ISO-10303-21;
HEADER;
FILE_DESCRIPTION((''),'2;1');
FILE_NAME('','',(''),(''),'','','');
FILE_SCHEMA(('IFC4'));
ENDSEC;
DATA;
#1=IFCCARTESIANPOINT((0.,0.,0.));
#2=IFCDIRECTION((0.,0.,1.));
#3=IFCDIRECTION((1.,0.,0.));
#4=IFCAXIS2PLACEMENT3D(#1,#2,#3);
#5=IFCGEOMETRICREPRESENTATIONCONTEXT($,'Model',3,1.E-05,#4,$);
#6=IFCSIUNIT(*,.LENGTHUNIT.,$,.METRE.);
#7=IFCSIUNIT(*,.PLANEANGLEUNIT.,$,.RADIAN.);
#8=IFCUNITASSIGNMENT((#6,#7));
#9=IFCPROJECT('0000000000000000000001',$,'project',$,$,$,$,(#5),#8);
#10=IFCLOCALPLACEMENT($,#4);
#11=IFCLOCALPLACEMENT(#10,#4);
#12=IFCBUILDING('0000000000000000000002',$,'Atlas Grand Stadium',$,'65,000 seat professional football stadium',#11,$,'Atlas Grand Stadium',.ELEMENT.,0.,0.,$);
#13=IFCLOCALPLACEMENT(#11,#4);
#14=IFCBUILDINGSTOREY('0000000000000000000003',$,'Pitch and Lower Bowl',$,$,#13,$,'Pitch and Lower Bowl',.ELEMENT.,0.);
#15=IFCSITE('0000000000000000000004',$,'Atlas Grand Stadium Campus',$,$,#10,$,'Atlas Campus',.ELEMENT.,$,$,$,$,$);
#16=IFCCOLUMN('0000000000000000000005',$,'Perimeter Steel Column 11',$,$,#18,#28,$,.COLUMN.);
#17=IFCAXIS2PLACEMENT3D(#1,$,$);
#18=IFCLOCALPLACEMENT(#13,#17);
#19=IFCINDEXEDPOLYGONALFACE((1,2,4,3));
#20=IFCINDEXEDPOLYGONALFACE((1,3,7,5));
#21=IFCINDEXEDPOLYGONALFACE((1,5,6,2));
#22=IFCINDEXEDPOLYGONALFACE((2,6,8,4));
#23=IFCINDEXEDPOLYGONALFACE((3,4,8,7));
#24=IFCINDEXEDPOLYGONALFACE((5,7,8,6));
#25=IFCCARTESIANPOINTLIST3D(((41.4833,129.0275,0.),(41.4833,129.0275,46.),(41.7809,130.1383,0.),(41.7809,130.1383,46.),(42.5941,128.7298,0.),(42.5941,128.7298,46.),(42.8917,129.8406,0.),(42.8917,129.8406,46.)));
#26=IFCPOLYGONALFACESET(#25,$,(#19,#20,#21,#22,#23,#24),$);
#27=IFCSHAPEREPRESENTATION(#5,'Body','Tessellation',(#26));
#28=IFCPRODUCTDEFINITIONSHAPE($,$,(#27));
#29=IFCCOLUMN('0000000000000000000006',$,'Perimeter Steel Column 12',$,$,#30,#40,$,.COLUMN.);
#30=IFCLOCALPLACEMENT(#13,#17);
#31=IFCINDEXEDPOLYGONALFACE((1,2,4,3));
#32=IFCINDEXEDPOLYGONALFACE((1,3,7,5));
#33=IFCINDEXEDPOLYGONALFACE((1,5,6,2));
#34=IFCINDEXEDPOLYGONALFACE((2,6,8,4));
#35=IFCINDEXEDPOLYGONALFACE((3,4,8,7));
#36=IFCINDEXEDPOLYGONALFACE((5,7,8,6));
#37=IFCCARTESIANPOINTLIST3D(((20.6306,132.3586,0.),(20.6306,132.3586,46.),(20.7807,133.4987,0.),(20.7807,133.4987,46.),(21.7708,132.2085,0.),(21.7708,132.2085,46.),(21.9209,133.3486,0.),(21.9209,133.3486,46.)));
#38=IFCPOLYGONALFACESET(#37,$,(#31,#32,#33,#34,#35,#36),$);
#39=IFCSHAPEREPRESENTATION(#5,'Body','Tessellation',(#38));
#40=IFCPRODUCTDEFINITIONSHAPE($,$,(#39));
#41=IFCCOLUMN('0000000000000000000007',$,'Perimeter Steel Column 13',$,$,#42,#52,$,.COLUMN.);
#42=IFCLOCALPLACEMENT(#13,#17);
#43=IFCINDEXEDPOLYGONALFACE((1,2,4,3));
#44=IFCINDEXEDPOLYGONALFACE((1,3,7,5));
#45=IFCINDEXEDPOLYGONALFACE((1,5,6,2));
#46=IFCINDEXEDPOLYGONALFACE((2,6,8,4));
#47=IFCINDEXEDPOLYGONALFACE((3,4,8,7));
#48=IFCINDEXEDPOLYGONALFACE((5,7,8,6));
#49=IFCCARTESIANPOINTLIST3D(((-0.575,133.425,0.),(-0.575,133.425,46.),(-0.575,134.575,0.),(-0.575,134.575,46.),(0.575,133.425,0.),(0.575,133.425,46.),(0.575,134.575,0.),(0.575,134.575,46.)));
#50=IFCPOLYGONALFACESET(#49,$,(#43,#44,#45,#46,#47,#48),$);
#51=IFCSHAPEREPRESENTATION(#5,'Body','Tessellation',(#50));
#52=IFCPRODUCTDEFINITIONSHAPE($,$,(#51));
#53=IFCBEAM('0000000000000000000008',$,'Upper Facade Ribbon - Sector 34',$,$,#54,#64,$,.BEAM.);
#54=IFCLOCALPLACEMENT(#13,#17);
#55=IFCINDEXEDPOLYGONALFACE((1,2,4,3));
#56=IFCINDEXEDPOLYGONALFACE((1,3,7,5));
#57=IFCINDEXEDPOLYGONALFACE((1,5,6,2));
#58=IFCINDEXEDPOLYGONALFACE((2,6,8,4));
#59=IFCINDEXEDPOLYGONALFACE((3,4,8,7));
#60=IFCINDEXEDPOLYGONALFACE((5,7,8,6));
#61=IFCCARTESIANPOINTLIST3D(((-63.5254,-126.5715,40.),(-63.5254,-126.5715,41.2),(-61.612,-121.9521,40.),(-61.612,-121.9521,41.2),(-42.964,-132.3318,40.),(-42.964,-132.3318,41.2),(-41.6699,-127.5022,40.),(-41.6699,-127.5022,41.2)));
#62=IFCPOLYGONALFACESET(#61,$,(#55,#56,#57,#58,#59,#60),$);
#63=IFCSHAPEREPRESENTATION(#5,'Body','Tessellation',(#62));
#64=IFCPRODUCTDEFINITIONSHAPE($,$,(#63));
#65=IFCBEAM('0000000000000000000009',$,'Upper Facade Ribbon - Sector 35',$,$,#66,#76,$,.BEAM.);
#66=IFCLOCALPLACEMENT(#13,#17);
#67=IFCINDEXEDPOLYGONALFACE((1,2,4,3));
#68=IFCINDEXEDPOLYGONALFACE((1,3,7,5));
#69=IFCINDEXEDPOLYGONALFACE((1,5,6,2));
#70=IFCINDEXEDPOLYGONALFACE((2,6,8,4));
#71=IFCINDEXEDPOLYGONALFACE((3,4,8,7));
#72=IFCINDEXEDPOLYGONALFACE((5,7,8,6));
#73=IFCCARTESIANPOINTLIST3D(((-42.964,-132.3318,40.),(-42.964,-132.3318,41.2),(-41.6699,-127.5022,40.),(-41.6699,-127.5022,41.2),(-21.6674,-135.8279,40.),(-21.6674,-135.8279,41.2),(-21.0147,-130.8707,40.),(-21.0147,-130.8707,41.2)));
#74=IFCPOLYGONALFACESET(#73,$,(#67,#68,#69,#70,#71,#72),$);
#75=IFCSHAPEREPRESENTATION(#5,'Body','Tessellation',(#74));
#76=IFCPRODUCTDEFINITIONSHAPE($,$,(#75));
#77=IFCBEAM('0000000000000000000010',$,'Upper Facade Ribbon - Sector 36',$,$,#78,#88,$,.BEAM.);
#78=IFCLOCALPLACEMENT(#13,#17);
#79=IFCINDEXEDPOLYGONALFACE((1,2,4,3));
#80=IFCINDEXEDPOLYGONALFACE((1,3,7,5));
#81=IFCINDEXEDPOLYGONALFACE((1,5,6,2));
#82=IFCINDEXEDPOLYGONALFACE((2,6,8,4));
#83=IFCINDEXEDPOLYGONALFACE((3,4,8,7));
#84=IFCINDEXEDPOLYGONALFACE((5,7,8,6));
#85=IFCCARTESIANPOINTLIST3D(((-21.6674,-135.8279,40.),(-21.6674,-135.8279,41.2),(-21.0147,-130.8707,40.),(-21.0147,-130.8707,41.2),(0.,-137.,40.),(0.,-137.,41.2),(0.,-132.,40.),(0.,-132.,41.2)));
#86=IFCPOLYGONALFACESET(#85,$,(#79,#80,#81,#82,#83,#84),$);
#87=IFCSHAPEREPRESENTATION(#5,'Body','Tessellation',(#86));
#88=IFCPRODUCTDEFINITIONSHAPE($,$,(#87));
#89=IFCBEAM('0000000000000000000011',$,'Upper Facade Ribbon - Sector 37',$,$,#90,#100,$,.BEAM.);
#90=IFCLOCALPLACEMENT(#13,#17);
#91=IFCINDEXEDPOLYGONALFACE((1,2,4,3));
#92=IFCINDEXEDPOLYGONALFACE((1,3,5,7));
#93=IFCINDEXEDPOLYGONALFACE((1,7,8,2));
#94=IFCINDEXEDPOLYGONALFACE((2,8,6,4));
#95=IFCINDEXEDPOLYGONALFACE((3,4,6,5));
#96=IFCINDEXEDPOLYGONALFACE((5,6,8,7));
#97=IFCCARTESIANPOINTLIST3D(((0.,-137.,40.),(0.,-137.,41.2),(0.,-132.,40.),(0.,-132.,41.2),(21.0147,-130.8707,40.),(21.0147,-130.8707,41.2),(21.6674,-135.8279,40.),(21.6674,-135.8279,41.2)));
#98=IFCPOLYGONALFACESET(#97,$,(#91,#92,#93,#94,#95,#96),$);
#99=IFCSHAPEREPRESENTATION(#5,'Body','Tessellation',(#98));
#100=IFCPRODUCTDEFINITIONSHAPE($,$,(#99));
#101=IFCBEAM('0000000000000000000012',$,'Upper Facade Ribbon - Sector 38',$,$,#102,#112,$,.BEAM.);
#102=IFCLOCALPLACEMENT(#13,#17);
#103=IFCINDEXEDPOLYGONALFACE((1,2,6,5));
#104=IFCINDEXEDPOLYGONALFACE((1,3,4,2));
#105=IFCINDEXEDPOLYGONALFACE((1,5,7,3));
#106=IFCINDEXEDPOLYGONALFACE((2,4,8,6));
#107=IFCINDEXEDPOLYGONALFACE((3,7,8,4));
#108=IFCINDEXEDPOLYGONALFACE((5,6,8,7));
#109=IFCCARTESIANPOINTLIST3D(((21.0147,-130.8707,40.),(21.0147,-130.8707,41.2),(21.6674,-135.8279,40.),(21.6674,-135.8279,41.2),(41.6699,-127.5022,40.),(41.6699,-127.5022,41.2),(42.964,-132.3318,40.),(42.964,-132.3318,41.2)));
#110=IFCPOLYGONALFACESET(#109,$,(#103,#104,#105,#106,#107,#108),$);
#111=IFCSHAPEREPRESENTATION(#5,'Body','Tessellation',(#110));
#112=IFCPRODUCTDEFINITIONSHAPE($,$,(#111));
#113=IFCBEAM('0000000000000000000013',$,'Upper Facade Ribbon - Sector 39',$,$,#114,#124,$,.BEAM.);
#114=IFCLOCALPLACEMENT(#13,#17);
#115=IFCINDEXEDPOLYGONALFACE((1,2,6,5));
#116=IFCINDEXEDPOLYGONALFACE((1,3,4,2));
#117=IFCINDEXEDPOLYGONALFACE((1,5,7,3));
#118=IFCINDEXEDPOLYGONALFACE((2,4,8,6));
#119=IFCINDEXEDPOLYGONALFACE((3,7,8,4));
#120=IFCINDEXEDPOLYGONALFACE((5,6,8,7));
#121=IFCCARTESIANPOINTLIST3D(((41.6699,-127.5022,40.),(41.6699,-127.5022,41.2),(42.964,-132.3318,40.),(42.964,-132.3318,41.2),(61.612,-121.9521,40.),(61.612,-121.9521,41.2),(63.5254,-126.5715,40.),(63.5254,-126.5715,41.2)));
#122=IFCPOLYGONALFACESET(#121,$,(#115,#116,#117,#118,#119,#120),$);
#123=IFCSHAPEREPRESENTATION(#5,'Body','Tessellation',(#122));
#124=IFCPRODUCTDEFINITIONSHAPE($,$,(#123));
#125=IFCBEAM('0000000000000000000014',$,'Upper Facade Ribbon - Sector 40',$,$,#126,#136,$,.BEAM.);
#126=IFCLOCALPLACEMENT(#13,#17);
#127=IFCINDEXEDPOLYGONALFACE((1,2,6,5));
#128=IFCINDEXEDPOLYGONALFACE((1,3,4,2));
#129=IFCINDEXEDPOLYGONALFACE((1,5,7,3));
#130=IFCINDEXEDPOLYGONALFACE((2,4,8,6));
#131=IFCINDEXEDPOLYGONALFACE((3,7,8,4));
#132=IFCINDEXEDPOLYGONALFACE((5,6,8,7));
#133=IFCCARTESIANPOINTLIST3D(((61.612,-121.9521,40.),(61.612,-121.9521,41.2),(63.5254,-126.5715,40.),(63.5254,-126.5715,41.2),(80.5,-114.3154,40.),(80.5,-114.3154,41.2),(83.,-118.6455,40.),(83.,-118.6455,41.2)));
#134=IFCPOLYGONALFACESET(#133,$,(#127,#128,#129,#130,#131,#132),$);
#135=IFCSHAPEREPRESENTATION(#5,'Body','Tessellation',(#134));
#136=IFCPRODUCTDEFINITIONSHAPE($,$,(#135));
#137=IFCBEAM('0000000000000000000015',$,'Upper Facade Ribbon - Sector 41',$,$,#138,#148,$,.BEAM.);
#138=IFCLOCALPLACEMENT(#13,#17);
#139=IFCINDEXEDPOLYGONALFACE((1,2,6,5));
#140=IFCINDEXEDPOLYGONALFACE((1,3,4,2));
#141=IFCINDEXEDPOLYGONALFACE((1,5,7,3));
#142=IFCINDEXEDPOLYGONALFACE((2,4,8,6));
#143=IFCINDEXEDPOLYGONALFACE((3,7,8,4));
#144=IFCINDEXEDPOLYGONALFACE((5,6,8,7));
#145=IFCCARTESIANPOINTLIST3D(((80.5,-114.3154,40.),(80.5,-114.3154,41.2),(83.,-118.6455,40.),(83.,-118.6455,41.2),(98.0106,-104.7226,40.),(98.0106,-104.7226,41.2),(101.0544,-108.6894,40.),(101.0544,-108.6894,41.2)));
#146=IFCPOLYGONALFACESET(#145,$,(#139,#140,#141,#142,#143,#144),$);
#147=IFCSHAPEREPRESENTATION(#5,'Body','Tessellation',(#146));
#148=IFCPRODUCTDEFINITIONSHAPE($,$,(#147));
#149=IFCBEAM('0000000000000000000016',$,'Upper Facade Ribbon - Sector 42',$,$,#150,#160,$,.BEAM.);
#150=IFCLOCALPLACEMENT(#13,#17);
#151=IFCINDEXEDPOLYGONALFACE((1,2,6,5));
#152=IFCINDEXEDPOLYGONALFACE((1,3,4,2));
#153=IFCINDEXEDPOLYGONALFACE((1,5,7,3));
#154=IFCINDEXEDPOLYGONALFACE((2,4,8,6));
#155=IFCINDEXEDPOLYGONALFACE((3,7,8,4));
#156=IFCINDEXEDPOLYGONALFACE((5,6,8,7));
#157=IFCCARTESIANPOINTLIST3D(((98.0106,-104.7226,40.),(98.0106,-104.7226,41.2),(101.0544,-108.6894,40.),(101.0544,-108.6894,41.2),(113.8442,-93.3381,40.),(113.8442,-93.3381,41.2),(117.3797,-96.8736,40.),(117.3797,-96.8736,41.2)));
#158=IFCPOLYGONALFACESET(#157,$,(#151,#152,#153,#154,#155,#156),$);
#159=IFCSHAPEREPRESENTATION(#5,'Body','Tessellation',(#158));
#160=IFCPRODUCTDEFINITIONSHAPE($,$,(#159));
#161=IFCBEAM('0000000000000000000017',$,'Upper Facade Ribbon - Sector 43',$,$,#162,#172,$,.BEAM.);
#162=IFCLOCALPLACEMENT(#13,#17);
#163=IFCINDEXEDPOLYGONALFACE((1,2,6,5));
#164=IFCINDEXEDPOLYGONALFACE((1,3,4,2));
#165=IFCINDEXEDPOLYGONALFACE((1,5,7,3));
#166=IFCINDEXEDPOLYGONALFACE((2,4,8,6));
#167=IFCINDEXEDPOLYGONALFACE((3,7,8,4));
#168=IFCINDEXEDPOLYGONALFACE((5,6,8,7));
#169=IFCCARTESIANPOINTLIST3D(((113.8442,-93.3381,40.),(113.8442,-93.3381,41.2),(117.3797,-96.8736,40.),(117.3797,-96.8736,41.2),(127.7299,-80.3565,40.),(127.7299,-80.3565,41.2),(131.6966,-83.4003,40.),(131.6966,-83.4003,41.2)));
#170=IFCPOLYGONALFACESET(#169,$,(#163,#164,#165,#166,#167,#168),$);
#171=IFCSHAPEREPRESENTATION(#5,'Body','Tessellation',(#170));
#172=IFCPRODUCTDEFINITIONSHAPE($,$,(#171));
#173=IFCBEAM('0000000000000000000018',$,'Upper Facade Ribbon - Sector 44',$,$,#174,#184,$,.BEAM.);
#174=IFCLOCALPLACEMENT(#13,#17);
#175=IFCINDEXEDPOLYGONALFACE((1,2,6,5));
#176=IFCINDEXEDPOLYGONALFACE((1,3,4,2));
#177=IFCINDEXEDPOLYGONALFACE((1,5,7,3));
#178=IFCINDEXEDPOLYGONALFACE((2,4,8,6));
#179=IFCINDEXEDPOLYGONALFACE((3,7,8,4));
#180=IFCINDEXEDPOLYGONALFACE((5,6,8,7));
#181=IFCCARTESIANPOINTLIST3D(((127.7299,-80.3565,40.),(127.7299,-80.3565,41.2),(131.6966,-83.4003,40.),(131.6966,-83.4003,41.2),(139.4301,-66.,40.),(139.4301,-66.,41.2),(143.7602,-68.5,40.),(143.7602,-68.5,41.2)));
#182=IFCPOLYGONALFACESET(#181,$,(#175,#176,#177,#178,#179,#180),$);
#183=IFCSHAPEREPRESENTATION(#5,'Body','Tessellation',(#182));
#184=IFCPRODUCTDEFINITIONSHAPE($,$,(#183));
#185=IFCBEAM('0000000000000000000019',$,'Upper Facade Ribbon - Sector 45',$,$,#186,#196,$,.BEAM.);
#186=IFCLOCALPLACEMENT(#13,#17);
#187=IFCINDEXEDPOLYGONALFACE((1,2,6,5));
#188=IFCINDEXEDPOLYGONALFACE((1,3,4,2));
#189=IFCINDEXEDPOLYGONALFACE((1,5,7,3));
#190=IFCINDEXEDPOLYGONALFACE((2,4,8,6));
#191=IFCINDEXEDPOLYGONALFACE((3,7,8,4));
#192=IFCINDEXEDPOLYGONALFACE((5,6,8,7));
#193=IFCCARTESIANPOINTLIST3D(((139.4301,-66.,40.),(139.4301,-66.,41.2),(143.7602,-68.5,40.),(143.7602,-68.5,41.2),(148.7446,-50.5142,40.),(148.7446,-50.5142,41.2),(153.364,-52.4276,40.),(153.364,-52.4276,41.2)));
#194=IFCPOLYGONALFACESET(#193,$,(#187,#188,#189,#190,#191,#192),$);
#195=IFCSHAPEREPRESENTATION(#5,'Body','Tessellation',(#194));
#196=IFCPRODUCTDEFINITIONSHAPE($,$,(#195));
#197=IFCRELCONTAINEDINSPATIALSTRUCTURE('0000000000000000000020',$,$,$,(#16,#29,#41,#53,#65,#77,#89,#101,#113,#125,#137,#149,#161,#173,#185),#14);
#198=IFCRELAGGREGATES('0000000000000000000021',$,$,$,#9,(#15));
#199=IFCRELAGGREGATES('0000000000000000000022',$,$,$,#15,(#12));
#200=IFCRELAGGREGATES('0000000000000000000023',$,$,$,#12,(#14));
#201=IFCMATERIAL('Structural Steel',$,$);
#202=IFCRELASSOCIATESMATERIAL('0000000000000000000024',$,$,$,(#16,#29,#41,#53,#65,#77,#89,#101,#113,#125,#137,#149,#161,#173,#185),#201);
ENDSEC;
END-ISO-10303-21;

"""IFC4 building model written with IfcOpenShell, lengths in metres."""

from ifc_helpers import new_model, si_unit, frame, origin_with_axes, origin_2d_with_axis, place, context, project, spatial, polyline, rectangle, outline, extrude, material, element, save


model = new_model("IFC4")

# Units and contexts
model_context = context("Model", 3, precision=1e-05, world=origin_with_axes())
ifc_project = project(units=[si_unit("LENGTHUNIT", "METRE"), si_unit("PLANEANGLEUNIT", "RADIAN")], contexts=[model_context])

# Site, building, storey
site_placement = place(None, origin_with_axes())
site = spatial("IfcSite", under=ifc_project, at=site_placement, Name="Atlas Grand Stadium Campus", LongName="Atlas Campus", CompositionType="ELEMENT")
building_placement = place(site_placement, origin_with_axes())
building = spatial("IfcBuilding", under=site, at=building_placement, Name="Atlas Grand Stadium", ObjectType="65,000 seat professional football stadium", LongName="Atlas Grand Stadium", CompositionType="ELEMENT", ElevationOfRefHeight=0.0, ElevationOfTerrain=0.0)
storey_placement = place(building_placement, origin_with_axes())
storey = spatial("IfcBuildingStorey", under=building, at=storey_placement, Name="Pitch and Lower Bowl", LongName="Pitch and Lower Bowl", CompositionType="ELEMENT", Elevation=0.0)

# Columns
ifc_material_1 = material(Name="Structural Steel")
for number, where, z_axis, x_axis, name in (
    (1, (42.1875, 129.4341, 0.0), (0.0, 0.0, 1.0), (-0.96593, 0.25882, 0.0), "Perimeter Steel Column 11"),
    (2, (21.2758, 132.8536, 0.0), (0.0, 0.0, 1.0), (-0.99144, 0.13053, 0.0), "Perimeter Steel Column 12"),
    (3, (0.0, 134.0, 0.0), (0.0, 0.0, 1.0), (-1.0, 0.0, 0.0), "Perimeter Steel Column 13"),
):
    element("IfcColumn", number, at=place(storey_placement, frame(where, z_axis=z_axis, x_axis=x_axis)), inside=storey, material=ifc_material_1, Name=name, PredefinedType="COLUMN", context=model_context, shape_type="SweptSolid", body=[
        extrude(rectangle(XDim=1.15, YDim=1.15, at=origin_2d_with_axis()), origin_with_axes(), (0.0, 0.0, 1.0), 46.0),
    ])

# Beams
beam_1_placement = place(storey_placement, frame((0.0, 0.0, 40.0), z_axis=(0.0, 0.0, 1.0), x_axis=(1.0, 0.0, 0.0)))
element("IfcBeam", 4, at=beam_1_placement, inside=storey, material=ifc_material_1, Name="Upper Facade Ribbon - Sector 34", PredefinedType="BEAM", context=model_context, shape_type="SweptSolid", body=[
    extrude(outline(polyline([(-63.5254, -126.5715), (-42.964, -132.3318), (-41.6699, -127.5022), (-61.612, -121.9521), (-63.5254, -126.5715)])), origin_with_axes(), (0.0, 0.0, 1.0), 1.2),
])
beam_2_placement = place(storey_placement, frame((0.0, 0.0, 40.0), z_axis=(0.0, 0.0, 1.0), x_axis=(1.0, 0.0, 0.0)))
element("IfcBeam", 5, at=beam_2_placement, inside=storey, material=ifc_material_1, Name="Upper Facade Ribbon - Sector 35", PredefinedType="BEAM", context=model_context, shape_type="SweptSolid", body=[
    extrude(outline(polyline([(-42.964, -132.3318), (-21.6673, -135.8279), (-21.0147, -130.8707), (-41.6699, -127.5022), (-42.964, -132.3318)])), origin_with_axes(), (0.0, 0.0, 1.0), 1.2),
])
beam_3_placement = place(storey_placement, frame((0.0, 0.0, 40.0), z_axis=(0.0, 0.0, 1.0), x_axis=(1.0, 0.0, 0.0)))
element("IfcBeam", 6, at=beam_3_placement, inside=storey, material=ifc_material_1, Name="Upper Facade Ribbon - Sector 36", PredefinedType="BEAM", context=model_context, shape_type="SweptSolid", body=[
    extrude(outline(polyline([(-21.6673, -135.8279), (0.0, -137.0), (0.0, -132.0), (-21.0147, -130.8707), (-21.6673, -135.8279)])), origin_with_axes(), (0.0, 0.0, 1.0), 1.2),
])
beam_4_placement = place(storey_placement, frame((0.0, 0.0, 40.0), z_axis=(0.0, 0.0, 1.0), x_axis=(1.0, 0.0, 0.0)))
element("IfcBeam", 7, at=beam_4_placement, inside=storey, material=ifc_material_1, Name="Upper Facade Ribbon - Sector 37", PredefinedType="BEAM", context=model_context, shape_type="SweptSolid", body=[
    extrude(outline(polyline([(0.0, -137.0), (21.6673, -135.8279), (21.0147, -130.8707), (0.0, -132.0), (0.0, -137.0)])), origin_with_axes(), (0.0, 0.0, 1.0), 1.2),
])
beam_5_placement = place(storey_placement, frame((0.0, 0.0, 40.0), z_axis=(0.0, 0.0, 1.0), x_axis=(1.0, 0.0, 0.0)))
element("IfcBeam", 8, at=beam_5_placement, inside=storey, material=ifc_material_1, Name="Upper Facade Ribbon - Sector 38", PredefinedType="BEAM", context=model_context, shape_type="SweptSolid", body=[
    extrude(outline(polyline([(21.6673, -135.8279), (42.964, -132.3318), (41.6699, -127.5022), (21.0147, -130.8707), (21.6673, -135.8279)])), origin_with_axes(), (0.0, 0.0, 1.0), 1.2),
])
beam_6_placement = place(storey_placement, frame((0.0, 0.0, 40.0), z_axis=(0.0, 0.0, 1.0), x_axis=(1.0, 0.0, 0.0)))
element("IfcBeam", 9, at=beam_6_placement, inside=storey, material=ifc_material_1, Name="Upper Facade Ribbon - Sector 39", PredefinedType="BEAM", context=model_context, shape_type="SweptSolid", body=[
    extrude(outline(polyline([(42.964, -132.3318), (63.5254, -126.5715), (61.612, -121.9521), (41.6699, -127.5022), (42.964, -132.3318)])), origin_with_axes(), (0.0, 0.0, 1.0), 1.2),
])
beam_7_placement = place(storey_placement, frame((0.0, 0.0, 40.0), z_axis=(0.0, 0.0, 1.0), x_axis=(1.0, 0.0, 0.0)))
element("IfcBeam", 10, at=beam_7_placement, inside=storey, material=ifc_material_1, Name="Upper Facade Ribbon - Sector 40", PredefinedType="BEAM", context=model_context, shape_type="SweptSolid", body=[
    extrude(outline(polyline([(63.5254, -126.5715), (83.0, -118.6455), (80.5, -114.3153), (61.612, -121.9521), (63.5254, -126.5715)])), origin_with_axes(), (0.0, 0.0, 1.0), 1.2),
])
beam_8_placement = place(storey_placement, frame((0.0, 0.0, 40.0), z_axis=(0.0, 0.0, 1.0), x_axis=(1.0, 0.0, 0.0)))
element("IfcBeam", 11, at=beam_8_placement, inside=storey, material=ifc_material_1, Name="Upper Facade Ribbon - Sector 41", PredefinedType="BEAM", context=model_context, shape_type="SweptSolid", body=[
    extrude(outline(polyline([(83.0, -118.6455), (101.0544, -108.6894), (98.0106, -104.7226), (80.5, -114.3153), (83.0, -118.6455)])), origin_with_axes(), (0.0, 0.0, 1.0), 1.2),
])
beam_9_placement = place(storey_placement, frame((0.0, 0.0, 40.0), z_axis=(0.0, 0.0, 1.0), x_axis=(1.0, 0.0, 0.0)))
element("IfcBeam", 12, at=beam_9_placement, inside=storey, material=ifc_material_1, Name="Upper Facade Ribbon - Sector 42", PredefinedType="BEAM", context=model_context, shape_type="SweptSolid", body=[
    extrude(outline(polyline([(101.0544, -108.6894), (117.3797, -96.8736), (113.8442, -93.3381), (98.0106, -104.7226), (101.0544, -108.6894)])), origin_with_axes(), (0.0, 0.0, 1.0), 1.2),
])
beam_10_placement = place(storey_placement, frame((0.0, 0.0, 40.0), z_axis=(0.0, 0.0, 1.0), x_axis=(1.0, 0.0, 0.0)))
element("IfcBeam", 13, at=beam_10_placement, inside=storey, material=ifc_material_1, Name="Upper Facade Ribbon - Sector 43", PredefinedType="BEAM", context=model_context, shape_type="SweptSolid", body=[
    extrude(outline(polyline([(117.3797, -96.8736), (131.6967, -83.4003), (127.7299, -80.3565), (113.8442, -93.3381), (117.3797, -96.8736)])), origin_with_axes(), (0.0, 0.0, 1.0), 1.2),
])
beam_11_placement = place(storey_placement, frame((0.0, 0.0, 40.0), z_axis=(0.0, 0.0, 1.0), x_axis=(1.0, 0.0, 0.0)))
element("IfcBeam", 14, at=beam_11_placement, inside=storey, material=ifc_material_1, Name="Upper Facade Ribbon - Sector 44", PredefinedType="BEAM", context=model_context, shape_type="SweptSolid", body=[
    extrude(outline(polyline([(131.6967, -83.4003), (143.7602, -68.5), (139.4301, -66.0), (127.7299, -80.3565), (131.6967, -83.4003)])), origin_with_axes(), (0.0, 0.0, 1.0), 1.2),
])
beam_12_placement = place(storey_placement, frame((0.0, 0.0, 40.0), z_axis=(0.0, 0.0, 1.0), x_axis=(1.0, 0.0, 0.0)))
element("IfcBeam", 15, at=beam_12_placement, inside=storey, material=ifc_material_1, Name="Upper Facade Ribbon - Sector 45", PredefinedType="BEAM", context=model_context, shape_type="SweptSolid", body=[
    extrude(outline(polyline([(143.7602, -68.5), (153.364, -52.4276), (148.7446, -50.5142), (139.4301, -66.0), (143.7602, -68.5)])), origin_with_axes(), (0.0, 0.0, 1.0), 1.2),
])

save(model, "model.ifc")
